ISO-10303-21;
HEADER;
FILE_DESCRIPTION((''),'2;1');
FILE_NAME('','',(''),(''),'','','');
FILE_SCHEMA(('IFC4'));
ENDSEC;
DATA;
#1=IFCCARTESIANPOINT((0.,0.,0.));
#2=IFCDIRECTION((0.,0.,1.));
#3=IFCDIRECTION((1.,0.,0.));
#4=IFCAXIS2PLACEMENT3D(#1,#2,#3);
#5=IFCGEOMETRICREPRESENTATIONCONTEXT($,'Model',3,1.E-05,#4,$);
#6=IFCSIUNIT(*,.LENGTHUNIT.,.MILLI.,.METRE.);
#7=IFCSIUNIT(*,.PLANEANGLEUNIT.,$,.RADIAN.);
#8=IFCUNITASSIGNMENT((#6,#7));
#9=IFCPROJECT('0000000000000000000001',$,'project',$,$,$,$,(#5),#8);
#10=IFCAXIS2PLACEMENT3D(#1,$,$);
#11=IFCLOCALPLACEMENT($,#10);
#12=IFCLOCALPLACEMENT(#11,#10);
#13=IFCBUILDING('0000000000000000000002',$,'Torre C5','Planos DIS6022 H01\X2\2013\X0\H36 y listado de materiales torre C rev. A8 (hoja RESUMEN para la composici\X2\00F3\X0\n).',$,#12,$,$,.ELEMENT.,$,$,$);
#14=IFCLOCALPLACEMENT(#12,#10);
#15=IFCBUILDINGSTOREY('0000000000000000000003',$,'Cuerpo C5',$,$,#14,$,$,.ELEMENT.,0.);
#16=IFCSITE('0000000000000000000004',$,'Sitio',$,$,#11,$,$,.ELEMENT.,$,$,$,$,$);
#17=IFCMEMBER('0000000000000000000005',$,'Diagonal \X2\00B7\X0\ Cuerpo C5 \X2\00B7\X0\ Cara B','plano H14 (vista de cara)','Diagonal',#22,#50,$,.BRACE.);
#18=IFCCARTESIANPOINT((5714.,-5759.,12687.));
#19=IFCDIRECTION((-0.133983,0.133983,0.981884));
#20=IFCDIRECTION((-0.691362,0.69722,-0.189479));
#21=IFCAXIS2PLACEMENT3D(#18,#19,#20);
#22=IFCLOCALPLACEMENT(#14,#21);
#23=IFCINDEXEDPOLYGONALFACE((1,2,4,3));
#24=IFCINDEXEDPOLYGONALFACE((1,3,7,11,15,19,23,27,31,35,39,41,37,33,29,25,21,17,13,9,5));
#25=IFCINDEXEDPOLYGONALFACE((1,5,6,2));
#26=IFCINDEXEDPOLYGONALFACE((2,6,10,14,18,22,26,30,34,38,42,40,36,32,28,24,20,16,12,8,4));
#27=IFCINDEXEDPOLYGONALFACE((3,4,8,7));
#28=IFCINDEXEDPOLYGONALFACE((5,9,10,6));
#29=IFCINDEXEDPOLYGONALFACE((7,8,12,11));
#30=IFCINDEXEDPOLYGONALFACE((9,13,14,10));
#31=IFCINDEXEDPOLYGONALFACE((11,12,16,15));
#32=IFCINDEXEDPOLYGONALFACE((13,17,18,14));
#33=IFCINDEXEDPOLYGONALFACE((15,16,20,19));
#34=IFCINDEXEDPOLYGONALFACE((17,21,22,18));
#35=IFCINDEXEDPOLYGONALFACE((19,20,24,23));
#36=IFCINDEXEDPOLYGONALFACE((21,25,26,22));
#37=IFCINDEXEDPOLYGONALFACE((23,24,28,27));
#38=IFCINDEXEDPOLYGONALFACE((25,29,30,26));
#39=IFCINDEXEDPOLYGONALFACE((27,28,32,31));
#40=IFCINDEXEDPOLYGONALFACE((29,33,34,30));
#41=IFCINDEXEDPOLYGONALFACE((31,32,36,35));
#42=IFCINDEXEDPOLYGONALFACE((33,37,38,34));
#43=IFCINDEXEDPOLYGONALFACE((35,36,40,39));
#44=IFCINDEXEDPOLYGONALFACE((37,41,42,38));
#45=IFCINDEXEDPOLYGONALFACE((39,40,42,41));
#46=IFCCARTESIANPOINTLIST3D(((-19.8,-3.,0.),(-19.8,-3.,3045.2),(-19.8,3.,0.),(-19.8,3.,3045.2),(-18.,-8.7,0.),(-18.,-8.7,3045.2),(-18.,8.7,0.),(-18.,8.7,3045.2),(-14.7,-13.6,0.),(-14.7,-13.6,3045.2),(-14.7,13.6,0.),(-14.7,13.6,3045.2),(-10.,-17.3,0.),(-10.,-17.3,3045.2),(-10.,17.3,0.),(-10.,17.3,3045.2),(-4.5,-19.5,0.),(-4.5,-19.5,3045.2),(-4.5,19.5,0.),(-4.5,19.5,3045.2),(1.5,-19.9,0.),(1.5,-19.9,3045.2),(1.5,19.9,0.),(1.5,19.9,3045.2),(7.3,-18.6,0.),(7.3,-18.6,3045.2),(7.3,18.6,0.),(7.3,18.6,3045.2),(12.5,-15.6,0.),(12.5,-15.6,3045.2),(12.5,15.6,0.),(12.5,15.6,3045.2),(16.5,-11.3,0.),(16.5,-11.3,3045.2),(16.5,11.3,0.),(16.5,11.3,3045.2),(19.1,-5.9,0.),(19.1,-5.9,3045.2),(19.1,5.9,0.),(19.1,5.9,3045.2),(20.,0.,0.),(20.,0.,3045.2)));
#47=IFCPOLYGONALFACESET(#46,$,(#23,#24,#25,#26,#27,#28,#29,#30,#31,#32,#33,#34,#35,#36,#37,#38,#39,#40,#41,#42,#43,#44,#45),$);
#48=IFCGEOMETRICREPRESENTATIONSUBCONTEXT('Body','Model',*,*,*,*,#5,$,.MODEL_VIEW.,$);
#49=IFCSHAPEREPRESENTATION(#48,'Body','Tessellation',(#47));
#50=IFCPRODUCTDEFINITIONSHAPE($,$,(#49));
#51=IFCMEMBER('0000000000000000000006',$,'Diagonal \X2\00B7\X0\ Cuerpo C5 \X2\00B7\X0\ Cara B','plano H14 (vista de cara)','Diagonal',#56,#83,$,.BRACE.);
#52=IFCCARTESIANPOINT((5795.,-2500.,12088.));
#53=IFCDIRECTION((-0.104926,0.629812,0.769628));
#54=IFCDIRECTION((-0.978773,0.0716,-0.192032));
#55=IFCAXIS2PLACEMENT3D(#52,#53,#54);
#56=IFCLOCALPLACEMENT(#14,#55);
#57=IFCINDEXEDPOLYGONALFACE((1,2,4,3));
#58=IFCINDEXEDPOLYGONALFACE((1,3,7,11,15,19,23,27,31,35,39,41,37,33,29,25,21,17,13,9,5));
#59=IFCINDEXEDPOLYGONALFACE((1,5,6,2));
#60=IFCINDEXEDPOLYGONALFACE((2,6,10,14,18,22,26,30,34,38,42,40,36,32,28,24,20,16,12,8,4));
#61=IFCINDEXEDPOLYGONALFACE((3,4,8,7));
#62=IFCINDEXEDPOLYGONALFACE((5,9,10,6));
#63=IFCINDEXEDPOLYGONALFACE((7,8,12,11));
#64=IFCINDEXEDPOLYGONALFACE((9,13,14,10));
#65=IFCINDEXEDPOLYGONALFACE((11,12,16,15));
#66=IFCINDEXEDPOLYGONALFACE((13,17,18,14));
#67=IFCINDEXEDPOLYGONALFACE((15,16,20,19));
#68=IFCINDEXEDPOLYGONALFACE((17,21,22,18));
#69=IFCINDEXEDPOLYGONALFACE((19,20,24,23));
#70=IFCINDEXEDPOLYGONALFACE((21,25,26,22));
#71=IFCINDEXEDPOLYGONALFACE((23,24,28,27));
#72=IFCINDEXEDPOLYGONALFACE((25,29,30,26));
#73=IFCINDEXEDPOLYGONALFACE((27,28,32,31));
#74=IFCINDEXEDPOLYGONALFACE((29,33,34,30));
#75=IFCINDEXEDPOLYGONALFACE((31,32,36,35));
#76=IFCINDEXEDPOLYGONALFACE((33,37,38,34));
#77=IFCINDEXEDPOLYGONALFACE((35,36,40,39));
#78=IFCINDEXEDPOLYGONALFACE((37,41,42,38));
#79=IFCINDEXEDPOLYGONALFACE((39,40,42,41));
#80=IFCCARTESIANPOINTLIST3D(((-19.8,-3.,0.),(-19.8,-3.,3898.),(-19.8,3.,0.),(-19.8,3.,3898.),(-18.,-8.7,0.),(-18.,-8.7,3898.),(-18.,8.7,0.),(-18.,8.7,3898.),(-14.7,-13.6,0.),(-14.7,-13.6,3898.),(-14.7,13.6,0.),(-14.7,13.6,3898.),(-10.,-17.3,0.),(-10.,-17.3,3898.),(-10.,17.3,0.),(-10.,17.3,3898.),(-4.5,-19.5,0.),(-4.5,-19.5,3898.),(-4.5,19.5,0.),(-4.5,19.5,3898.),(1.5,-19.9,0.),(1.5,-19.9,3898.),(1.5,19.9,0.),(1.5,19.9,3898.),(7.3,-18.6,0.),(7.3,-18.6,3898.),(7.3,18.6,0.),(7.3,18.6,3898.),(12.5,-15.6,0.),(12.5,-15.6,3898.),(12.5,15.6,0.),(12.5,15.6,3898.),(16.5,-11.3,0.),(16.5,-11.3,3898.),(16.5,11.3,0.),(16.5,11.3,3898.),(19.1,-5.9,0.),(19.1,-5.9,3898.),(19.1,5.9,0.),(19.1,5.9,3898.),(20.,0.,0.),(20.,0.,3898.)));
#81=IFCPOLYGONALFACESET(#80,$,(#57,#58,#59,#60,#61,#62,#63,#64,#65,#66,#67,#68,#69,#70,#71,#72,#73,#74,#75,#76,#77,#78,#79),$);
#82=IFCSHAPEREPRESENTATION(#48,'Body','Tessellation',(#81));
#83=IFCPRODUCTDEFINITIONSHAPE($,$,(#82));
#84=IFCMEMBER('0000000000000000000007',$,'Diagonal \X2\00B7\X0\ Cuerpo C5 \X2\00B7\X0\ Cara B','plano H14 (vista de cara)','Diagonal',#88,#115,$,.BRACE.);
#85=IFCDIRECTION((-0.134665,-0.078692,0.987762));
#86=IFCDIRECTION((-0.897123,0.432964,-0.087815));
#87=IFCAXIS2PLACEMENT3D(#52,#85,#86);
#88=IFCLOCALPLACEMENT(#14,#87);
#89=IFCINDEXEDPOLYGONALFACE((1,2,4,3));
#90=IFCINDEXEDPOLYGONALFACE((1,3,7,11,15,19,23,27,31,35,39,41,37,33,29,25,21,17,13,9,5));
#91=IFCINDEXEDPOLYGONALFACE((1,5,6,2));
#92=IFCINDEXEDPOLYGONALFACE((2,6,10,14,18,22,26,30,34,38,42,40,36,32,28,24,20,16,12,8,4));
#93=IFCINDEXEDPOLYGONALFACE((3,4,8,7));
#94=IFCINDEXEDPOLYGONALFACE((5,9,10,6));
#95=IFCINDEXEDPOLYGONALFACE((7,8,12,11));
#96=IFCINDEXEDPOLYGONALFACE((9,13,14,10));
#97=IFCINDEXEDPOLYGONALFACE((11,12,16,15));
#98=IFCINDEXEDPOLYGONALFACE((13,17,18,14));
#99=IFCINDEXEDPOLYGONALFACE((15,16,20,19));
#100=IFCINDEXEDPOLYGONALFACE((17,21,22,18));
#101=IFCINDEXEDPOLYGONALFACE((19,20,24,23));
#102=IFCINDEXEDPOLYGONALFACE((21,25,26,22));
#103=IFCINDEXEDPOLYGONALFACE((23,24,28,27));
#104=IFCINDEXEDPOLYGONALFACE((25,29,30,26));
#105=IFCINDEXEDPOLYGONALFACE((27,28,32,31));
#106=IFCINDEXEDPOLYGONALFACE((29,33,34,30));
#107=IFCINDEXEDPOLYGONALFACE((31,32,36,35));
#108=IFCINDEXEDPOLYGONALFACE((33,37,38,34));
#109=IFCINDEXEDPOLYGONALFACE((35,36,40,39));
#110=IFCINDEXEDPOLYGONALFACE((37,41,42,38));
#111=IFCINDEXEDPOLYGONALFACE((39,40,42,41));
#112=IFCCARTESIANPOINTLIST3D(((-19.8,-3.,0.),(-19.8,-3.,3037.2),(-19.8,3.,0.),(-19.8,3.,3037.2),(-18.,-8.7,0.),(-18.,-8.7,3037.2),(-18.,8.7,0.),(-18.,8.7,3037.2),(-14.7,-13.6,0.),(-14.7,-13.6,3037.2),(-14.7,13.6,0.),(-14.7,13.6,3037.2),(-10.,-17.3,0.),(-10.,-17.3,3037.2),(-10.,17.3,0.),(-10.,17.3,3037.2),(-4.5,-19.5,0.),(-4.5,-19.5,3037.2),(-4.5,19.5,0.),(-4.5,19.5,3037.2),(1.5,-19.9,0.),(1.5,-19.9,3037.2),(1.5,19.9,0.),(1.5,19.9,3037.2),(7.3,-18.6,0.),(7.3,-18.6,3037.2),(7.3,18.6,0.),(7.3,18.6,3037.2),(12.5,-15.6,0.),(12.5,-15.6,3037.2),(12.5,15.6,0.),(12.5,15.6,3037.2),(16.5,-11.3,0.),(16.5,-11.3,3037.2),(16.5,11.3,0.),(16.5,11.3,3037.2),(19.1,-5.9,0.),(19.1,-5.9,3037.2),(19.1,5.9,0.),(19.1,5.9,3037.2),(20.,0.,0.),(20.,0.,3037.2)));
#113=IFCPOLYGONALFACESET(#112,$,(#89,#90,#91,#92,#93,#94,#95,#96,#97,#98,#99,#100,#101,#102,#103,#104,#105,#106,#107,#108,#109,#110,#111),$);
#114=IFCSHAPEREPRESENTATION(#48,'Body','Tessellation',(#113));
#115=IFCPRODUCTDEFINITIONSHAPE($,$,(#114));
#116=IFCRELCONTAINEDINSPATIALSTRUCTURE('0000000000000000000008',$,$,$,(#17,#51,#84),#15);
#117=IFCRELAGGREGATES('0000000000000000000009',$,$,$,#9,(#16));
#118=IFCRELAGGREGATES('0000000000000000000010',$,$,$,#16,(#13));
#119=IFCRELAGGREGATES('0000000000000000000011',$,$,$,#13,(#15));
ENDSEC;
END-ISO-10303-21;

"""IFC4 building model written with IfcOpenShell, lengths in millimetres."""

from ifc_helpers import new_model, si_unit, frame, origin, origin_with_axes, place, context, subcontext, project, spatial, circle, extrude, element, save


model = new_model("IFC4")

# Units and contexts
model_context = context("Model", 3, precision=1e-05, world=origin_with_axes())
body_context = subcontext(model_context, "Body", "Model", "MODEL_VIEW")
ifc_project = project(units=[si_unit("LENGTHUNIT", "METRE", prefix="MILLI"), si_unit("PLANEANGLEUNIT", "RADIAN")], contexts=[model_context])

# Site, building, storey
site_placement = place(None, origin())
site = spatial("IfcSite", under=ifc_project, at=site_placement, Name="Sitio", CompositionType="ELEMENT")
building_placement = place(site_placement, origin())
building = spatial("IfcBuilding", under=site, at=building_placement, Name="Torre C5", Description="Planos DIS6022 H01–H36 y listado de materiales torre C rev. A8 (hoja RESUMEN para la composición).", CompositionType="ELEMENT")
storey_placement = place(building_placement, origin())
storey = spatial("IfcBuildingStorey", under=building, at=storey_placement, Name="Cuerpo C5", CompositionType="ELEMENT", Elevation=0.0)

# Members
member_1_placement = place(storey_placement, frame((5714.0, -5759.0, 12687.0), z_axis=(-0.133983, 0.133983, 0.981884), x_axis=(-0.691362, 0.69722, -0.189479)))
element("IfcMember", 1, at=member_1_placement, inside=storey, Name="Diagonal · Cuerpo C5 · Cara B", Description="plano H14 (vista de cara)", ObjectType="Diagonal", PredefinedType="BRACE", context=body_context, shape_type="SweptSolid", body=[
    extrude(circle(Radius=20.0), None, (0.0, 0.0, 1.0), 3045.2),
])
member_2_placement = place(storey_placement, frame((5795.0, -2500.0, 12088.0), z_axis=(-0.104926, 0.629812, 0.769628), x_axis=(-0.978773, 0.0716, -0.192032)))
element("IfcMember", 2, at=member_2_placement, inside=storey, Name="Diagonal · Cuerpo C5 · Cara B", Description="plano H14 (vista de cara)", ObjectType="Diagonal", PredefinedType="BRACE", context=body_context, shape_type="SweptSolid", body=[
    extrude(circle(Radius=20.0), None, (0.0, 0.0, 1.0), 3898.0),
])
member_3_placement = place(storey_placement, frame((5795.0, -2500.0, 12088.0), z_axis=(-0.134665, -0.078692, 0.987762), x_axis=(-0.897123, 0.432964, -0.087815)))
element("IfcMember", 3, at=member_3_placement, inside=storey, Name="Diagonal · Cuerpo C5 · Cara B", Description="plano H14 (vista de cara)", ObjectType="Diagonal", PredefinedType="BRACE", context=body_context, shape_type="SweptSolid", body=[
    extrude(circle(Radius=20.0), None, (0.0, 0.0, 1.0), 3037.2),
])

save(model, "model.ifc")
